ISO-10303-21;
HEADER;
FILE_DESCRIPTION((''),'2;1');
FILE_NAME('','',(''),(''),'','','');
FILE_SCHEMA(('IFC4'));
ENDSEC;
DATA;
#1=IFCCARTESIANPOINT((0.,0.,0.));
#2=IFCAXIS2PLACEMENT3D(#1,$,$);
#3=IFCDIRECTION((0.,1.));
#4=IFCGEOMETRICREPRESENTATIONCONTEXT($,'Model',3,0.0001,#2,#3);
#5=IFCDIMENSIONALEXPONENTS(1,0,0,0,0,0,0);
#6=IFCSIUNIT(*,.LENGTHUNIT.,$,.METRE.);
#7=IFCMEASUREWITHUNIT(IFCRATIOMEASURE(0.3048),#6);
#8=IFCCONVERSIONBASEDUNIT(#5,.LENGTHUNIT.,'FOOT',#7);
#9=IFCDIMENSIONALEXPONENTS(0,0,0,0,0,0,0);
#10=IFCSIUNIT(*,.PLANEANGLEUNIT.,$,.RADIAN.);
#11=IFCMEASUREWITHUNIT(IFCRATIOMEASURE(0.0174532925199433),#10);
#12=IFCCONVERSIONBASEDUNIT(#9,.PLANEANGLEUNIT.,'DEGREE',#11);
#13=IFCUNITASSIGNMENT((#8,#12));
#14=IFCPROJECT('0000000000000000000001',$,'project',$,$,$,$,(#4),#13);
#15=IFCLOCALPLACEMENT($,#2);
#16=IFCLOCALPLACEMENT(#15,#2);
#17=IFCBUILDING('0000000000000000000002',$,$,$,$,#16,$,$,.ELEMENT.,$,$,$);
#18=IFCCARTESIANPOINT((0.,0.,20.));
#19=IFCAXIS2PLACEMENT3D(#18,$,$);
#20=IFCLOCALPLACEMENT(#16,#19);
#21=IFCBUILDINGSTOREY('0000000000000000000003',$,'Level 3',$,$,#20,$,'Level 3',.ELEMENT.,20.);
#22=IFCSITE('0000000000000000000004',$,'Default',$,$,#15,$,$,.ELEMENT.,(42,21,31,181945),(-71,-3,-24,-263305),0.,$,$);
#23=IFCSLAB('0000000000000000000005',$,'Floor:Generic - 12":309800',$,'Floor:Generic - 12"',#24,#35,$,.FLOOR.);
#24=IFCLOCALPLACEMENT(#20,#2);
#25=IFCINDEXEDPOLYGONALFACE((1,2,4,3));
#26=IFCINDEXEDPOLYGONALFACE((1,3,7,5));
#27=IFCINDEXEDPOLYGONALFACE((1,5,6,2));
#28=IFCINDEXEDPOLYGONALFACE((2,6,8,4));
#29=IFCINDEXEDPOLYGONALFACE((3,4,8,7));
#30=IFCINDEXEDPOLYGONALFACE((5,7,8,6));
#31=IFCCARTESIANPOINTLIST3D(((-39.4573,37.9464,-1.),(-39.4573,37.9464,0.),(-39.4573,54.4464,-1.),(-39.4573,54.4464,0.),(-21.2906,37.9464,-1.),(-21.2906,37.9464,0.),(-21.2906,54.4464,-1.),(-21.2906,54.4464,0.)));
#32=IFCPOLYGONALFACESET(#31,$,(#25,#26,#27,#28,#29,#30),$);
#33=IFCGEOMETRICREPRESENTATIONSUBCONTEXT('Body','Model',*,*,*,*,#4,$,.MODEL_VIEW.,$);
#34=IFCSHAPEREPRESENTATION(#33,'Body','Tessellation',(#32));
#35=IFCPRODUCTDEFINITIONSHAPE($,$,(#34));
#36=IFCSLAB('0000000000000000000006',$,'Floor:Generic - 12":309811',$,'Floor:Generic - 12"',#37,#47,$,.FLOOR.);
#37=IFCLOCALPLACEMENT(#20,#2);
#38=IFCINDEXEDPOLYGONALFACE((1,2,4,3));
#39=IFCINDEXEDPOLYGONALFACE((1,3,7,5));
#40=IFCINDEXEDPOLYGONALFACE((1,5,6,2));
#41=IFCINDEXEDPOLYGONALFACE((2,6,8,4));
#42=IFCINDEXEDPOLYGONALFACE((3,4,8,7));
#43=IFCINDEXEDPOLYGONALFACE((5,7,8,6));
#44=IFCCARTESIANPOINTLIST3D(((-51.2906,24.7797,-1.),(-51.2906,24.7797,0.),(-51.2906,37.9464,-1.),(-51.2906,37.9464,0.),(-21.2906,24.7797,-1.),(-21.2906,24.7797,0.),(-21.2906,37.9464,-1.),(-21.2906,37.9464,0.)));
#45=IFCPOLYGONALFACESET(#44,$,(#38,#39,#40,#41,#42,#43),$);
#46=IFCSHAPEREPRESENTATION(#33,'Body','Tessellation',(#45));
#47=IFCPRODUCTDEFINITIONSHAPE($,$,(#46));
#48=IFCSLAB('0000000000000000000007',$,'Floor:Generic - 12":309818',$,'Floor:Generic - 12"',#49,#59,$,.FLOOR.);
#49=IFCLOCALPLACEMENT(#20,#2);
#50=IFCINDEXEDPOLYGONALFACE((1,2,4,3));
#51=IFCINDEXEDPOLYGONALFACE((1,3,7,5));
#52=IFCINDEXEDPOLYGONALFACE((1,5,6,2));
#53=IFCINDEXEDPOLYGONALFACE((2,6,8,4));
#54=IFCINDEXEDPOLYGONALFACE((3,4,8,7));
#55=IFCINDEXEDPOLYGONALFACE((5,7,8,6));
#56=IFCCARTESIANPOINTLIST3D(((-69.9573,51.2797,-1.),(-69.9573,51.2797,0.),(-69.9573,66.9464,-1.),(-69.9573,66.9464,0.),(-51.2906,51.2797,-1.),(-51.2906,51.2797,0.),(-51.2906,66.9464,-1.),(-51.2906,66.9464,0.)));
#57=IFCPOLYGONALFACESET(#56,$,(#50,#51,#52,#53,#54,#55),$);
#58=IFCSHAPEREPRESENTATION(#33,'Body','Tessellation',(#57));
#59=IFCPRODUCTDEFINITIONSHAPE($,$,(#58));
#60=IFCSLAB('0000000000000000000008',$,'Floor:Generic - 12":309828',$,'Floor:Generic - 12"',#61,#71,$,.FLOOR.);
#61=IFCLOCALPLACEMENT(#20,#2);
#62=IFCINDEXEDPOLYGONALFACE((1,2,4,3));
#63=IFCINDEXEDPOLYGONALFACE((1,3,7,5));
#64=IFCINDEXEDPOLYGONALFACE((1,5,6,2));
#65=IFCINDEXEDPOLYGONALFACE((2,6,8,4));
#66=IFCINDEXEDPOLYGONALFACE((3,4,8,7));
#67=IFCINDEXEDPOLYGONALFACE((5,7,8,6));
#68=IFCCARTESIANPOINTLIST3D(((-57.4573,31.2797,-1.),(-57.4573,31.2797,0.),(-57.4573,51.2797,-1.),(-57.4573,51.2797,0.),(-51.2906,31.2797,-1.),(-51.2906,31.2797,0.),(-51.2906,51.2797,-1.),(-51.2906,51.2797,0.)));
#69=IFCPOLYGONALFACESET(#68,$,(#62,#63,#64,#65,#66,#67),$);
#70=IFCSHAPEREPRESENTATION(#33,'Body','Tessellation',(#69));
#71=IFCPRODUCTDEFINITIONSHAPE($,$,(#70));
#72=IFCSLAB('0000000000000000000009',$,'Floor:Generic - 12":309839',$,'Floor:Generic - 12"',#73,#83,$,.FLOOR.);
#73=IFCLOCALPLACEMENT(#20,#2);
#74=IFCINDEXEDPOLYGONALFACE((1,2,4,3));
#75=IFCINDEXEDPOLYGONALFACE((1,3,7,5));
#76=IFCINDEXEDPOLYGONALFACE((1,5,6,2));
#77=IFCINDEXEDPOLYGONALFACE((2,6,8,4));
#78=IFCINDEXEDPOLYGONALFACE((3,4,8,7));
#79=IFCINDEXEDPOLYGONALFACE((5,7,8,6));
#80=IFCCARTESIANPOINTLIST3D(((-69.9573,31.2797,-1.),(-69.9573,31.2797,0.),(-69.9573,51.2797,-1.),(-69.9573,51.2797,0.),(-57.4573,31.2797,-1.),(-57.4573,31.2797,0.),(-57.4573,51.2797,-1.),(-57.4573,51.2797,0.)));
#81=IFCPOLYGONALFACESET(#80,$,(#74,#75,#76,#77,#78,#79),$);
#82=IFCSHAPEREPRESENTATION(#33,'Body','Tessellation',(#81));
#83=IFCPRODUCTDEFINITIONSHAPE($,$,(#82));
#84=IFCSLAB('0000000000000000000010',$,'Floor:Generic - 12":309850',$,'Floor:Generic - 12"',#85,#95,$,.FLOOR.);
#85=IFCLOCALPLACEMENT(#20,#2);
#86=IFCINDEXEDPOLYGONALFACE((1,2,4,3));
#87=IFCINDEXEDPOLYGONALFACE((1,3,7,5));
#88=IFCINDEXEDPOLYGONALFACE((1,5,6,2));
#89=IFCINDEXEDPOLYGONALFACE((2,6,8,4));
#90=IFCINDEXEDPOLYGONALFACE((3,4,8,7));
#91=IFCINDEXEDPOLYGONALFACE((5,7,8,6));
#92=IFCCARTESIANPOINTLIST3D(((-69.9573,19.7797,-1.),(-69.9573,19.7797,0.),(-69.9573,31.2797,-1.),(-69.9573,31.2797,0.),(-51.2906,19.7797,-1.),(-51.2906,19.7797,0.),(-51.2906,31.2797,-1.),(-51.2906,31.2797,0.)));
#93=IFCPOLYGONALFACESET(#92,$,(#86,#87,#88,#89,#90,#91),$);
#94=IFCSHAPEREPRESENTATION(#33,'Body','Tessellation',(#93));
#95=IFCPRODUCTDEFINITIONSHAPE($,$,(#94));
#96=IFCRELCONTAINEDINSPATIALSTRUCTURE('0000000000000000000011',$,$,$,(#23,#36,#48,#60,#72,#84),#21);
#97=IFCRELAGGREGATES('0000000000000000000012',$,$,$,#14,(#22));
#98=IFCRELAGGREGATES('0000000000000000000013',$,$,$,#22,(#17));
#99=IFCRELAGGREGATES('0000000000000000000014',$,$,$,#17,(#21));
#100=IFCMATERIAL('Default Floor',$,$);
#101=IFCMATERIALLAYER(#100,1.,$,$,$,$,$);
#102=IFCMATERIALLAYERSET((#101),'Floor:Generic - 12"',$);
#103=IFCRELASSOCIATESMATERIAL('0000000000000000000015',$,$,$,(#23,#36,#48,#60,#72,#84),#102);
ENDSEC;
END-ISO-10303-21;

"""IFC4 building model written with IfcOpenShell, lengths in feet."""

from ifc_helpers import new_model, entity, si_unit, converted_unit, direction, frame, frame_2d, origin, place, context, subcontext, project, spatial, rectangle, extrude, material, layer, layer_set, layer_usage, element, save


model = new_model("IFC4")

# Units and contexts
model_context = context("Model", 3, precision=0.0001, world=origin(), true_north=direction((0.0, 1.0)))
body_context = subcontext(model_context, "Body", "Model", "MODEL_VIEW")
ifc_project = project(units=[converted_unit("LENGTHUNIT", "FOOT", entity("IfcRatioMeasure", 0.3048), si_unit("LENGTHUNIT", "METRE"), dimensions=[1, 0, 0, 0, 0, 0, 0]), converted_unit("PLANEANGLEUNIT", "DEGREE", entity("IfcRatioMeasure", 0.0174532925199433), si_unit("PLANEANGLEUNIT", "RADIAN"), dimensions=[0, 0, 0, 0, 0, 0, 0])], contexts=[model_context])

# Site, building, storey
site_placement = place(None, origin())
site = spatial("IfcSite", under=ifc_project, at=site_placement, Name="Default", CompositionType="ELEMENT", RefLatitude=(42, 21, 31, 181945), RefLongitude=(-71, -3, -24, -263305), RefElevation=0.0)
building_placement = place(site_placement, origin())
building = spatial("IfcBuilding", under=site, at=building_placement, CompositionType="ELEMENT")
storey_placement = place(building_placement, frame((0.0, 0.0, 20.0)))
storey = spatial("IfcBuildingStorey", under=building, at=storey_placement, Name="Level 3", LongName="Level 3", CompositionType="ELEMENT", Elevation=20.0)

# Slabs
ifc_material = material(Name="Default Floor")
ifc_layer = layer(ifc_material, 1.0)
ifc_layer_set = layer_set([ifc_layer], Name="Floor:Generic - 12\"")
ifc_layer_usage_1 = layer_usage(ifc_layer_set, "AXIS3", "POSITIVE", 0.0)
slab_1_placement = place(storey_placement, origin())
element("IfcSlab", 1, at=slab_1_placement, inside=storey, material=ifc_layer_usage_1, Name="Floor:Generic - 12\":309800", ObjectType="Floor:Generic - 12\"", PredefinedType="FLOOR", context=body_context, shape_type="SweptSolid", body=[
    extrude(rectangle(XDim=16.5, YDim=18.1667, at=frame_2d((0.0, 0.0), x_axis=(1.0, 0.0))), frame((-30.3739, 46.1964, 0.0), z_axis=(0.0, 0.0, -1.0), x_axis=(0.0, 1.0, 0.0)), (0.0, 0.0, 1.0), 1.0),
])
ifc_layer_usage_2 = layer_usage(ifc_layer_set, "AXIS3", "POSITIVE", 0.0)
slab_2_placement = place(storey_placement, origin())
element("IfcSlab", 2, at=slab_2_placement, inside=storey, material=ifc_layer_usage_2, Name="Floor:Generic - 12\":309811", ObjectType="Floor:Generic - 12\"", PredefinedType="FLOOR", context=body_context, shape_type="SweptSolid", body=[
    extrude(rectangle(XDim=13.1667, YDim=30.0, at=frame_2d((0.0, 0.0), x_axis=(1.0, 0.0))), frame((-36.2906, 31.3631, 0.0), z_axis=(0.0, 0.0, -1.0), x_axis=(0.0, 1.0, 0.0)), (0.0, 0.0, 1.0), 1.0),
])
ifc_layer_usage_3 = layer_usage(ifc_layer_set, "AXIS3", "POSITIVE", 0.0)
slab_3_placement = place(storey_placement, origin())
element("IfcSlab", 3, at=slab_3_placement, inside=storey, material=ifc_layer_usage_3, Name="Floor:Generic - 12\":309818", ObjectType="Floor:Generic - 12\"", PredefinedType="FLOOR", context=body_context, shape_type="SweptSolid", body=[
    extrude(rectangle(XDim=15.6667, YDim=18.6667, at=frame_2d((0.0, 0.0), x_axis=(1.0, 0.0))), frame((-60.6239, 59.1131, 0.0), z_axis=(0.0, 0.0, -1.0), x_axis=(0.0, 1.0, 0.0)), (0.0, 0.0, 1.0), 1.0),
])
ifc_layer_usage_4 = layer_usage(ifc_layer_set, "AXIS3", "POSITIVE", 0.0)
slab_4_placement = place(storey_placement, origin())
element("IfcSlab", 4, at=slab_4_placement, inside=storey, material=ifc_layer_usage_4, Name="Floor:Generic - 12\":309828", ObjectType="Floor:Generic - 12\"", PredefinedType="FLOOR", context=body_context, shape_type="SweptSolid", body=[
    extrude(rectangle(XDim=20.0, YDim=6.1667, at=frame_2d((0.0, 0.0), x_axis=(1.0, 0.0))), frame((-54.3739, 41.2797, 0.0), z_axis=(0.0, 0.0, -1.0), x_axis=(0.0, 1.0, 0.0)), (0.0, 0.0, 1.0), 1.0),
])
ifc_layer_usage_5 = layer_usage(ifc_layer_set, "AXIS3", "POSITIVE", 0.0)
slab_5_placement = place(storey_placement, origin())
element("IfcSlab", 5, at=slab_5_placement, inside=storey, material=ifc_layer_usage_5, Name="Floor:Generic - 12\":309839", ObjectType="Floor:Generic - 12\"", PredefinedType="FLOOR", context=body_context, shape_type="SweptSolid", body=[
    extrude(rectangle(XDim=20.0, YDim=12.5, at=frame_2d((0.0, 0.0), x_axis=(1.0, 0.0))), frame((-63.7073, 41.2797, 0.0), z_axis=(0.0, 0.0, -1.0), x_axis=(0.0, 1.0, 0.0)), (0.0, 0.0, 1.0), 1.0),
])
ifc_layer_usage_6 = layer_usage(ifc_layer_set, "AXIS3", "POSITIVE", 0.0)
slab_6_placement = place(storey_placement, origin())
element("IfcSlab", 6, at=slab_6_placement, inside=storey, material=ifc_layer_usage_6, Name="Floor:Generic - 12\":309850", ObjectType="Floor:Generic - 12\"", PredefinedType="FLOOR", context=body_context, shape_type="SweptSolid", body=[
    extrude(rectangle(XDim=11.5, YDim=18.6667, at=frame_2d((0.0, 0.0), x_axis=(1.0, 0.0))), frame((-60.6239, 25.5297, 0.0), z_axis=(0.0, 0.0, -1.0), x_axis=(0.0, 1.0, 0.0)), (0.0, 0.0, 1.0), 1.0),
])

save(model, "model.ifc")
